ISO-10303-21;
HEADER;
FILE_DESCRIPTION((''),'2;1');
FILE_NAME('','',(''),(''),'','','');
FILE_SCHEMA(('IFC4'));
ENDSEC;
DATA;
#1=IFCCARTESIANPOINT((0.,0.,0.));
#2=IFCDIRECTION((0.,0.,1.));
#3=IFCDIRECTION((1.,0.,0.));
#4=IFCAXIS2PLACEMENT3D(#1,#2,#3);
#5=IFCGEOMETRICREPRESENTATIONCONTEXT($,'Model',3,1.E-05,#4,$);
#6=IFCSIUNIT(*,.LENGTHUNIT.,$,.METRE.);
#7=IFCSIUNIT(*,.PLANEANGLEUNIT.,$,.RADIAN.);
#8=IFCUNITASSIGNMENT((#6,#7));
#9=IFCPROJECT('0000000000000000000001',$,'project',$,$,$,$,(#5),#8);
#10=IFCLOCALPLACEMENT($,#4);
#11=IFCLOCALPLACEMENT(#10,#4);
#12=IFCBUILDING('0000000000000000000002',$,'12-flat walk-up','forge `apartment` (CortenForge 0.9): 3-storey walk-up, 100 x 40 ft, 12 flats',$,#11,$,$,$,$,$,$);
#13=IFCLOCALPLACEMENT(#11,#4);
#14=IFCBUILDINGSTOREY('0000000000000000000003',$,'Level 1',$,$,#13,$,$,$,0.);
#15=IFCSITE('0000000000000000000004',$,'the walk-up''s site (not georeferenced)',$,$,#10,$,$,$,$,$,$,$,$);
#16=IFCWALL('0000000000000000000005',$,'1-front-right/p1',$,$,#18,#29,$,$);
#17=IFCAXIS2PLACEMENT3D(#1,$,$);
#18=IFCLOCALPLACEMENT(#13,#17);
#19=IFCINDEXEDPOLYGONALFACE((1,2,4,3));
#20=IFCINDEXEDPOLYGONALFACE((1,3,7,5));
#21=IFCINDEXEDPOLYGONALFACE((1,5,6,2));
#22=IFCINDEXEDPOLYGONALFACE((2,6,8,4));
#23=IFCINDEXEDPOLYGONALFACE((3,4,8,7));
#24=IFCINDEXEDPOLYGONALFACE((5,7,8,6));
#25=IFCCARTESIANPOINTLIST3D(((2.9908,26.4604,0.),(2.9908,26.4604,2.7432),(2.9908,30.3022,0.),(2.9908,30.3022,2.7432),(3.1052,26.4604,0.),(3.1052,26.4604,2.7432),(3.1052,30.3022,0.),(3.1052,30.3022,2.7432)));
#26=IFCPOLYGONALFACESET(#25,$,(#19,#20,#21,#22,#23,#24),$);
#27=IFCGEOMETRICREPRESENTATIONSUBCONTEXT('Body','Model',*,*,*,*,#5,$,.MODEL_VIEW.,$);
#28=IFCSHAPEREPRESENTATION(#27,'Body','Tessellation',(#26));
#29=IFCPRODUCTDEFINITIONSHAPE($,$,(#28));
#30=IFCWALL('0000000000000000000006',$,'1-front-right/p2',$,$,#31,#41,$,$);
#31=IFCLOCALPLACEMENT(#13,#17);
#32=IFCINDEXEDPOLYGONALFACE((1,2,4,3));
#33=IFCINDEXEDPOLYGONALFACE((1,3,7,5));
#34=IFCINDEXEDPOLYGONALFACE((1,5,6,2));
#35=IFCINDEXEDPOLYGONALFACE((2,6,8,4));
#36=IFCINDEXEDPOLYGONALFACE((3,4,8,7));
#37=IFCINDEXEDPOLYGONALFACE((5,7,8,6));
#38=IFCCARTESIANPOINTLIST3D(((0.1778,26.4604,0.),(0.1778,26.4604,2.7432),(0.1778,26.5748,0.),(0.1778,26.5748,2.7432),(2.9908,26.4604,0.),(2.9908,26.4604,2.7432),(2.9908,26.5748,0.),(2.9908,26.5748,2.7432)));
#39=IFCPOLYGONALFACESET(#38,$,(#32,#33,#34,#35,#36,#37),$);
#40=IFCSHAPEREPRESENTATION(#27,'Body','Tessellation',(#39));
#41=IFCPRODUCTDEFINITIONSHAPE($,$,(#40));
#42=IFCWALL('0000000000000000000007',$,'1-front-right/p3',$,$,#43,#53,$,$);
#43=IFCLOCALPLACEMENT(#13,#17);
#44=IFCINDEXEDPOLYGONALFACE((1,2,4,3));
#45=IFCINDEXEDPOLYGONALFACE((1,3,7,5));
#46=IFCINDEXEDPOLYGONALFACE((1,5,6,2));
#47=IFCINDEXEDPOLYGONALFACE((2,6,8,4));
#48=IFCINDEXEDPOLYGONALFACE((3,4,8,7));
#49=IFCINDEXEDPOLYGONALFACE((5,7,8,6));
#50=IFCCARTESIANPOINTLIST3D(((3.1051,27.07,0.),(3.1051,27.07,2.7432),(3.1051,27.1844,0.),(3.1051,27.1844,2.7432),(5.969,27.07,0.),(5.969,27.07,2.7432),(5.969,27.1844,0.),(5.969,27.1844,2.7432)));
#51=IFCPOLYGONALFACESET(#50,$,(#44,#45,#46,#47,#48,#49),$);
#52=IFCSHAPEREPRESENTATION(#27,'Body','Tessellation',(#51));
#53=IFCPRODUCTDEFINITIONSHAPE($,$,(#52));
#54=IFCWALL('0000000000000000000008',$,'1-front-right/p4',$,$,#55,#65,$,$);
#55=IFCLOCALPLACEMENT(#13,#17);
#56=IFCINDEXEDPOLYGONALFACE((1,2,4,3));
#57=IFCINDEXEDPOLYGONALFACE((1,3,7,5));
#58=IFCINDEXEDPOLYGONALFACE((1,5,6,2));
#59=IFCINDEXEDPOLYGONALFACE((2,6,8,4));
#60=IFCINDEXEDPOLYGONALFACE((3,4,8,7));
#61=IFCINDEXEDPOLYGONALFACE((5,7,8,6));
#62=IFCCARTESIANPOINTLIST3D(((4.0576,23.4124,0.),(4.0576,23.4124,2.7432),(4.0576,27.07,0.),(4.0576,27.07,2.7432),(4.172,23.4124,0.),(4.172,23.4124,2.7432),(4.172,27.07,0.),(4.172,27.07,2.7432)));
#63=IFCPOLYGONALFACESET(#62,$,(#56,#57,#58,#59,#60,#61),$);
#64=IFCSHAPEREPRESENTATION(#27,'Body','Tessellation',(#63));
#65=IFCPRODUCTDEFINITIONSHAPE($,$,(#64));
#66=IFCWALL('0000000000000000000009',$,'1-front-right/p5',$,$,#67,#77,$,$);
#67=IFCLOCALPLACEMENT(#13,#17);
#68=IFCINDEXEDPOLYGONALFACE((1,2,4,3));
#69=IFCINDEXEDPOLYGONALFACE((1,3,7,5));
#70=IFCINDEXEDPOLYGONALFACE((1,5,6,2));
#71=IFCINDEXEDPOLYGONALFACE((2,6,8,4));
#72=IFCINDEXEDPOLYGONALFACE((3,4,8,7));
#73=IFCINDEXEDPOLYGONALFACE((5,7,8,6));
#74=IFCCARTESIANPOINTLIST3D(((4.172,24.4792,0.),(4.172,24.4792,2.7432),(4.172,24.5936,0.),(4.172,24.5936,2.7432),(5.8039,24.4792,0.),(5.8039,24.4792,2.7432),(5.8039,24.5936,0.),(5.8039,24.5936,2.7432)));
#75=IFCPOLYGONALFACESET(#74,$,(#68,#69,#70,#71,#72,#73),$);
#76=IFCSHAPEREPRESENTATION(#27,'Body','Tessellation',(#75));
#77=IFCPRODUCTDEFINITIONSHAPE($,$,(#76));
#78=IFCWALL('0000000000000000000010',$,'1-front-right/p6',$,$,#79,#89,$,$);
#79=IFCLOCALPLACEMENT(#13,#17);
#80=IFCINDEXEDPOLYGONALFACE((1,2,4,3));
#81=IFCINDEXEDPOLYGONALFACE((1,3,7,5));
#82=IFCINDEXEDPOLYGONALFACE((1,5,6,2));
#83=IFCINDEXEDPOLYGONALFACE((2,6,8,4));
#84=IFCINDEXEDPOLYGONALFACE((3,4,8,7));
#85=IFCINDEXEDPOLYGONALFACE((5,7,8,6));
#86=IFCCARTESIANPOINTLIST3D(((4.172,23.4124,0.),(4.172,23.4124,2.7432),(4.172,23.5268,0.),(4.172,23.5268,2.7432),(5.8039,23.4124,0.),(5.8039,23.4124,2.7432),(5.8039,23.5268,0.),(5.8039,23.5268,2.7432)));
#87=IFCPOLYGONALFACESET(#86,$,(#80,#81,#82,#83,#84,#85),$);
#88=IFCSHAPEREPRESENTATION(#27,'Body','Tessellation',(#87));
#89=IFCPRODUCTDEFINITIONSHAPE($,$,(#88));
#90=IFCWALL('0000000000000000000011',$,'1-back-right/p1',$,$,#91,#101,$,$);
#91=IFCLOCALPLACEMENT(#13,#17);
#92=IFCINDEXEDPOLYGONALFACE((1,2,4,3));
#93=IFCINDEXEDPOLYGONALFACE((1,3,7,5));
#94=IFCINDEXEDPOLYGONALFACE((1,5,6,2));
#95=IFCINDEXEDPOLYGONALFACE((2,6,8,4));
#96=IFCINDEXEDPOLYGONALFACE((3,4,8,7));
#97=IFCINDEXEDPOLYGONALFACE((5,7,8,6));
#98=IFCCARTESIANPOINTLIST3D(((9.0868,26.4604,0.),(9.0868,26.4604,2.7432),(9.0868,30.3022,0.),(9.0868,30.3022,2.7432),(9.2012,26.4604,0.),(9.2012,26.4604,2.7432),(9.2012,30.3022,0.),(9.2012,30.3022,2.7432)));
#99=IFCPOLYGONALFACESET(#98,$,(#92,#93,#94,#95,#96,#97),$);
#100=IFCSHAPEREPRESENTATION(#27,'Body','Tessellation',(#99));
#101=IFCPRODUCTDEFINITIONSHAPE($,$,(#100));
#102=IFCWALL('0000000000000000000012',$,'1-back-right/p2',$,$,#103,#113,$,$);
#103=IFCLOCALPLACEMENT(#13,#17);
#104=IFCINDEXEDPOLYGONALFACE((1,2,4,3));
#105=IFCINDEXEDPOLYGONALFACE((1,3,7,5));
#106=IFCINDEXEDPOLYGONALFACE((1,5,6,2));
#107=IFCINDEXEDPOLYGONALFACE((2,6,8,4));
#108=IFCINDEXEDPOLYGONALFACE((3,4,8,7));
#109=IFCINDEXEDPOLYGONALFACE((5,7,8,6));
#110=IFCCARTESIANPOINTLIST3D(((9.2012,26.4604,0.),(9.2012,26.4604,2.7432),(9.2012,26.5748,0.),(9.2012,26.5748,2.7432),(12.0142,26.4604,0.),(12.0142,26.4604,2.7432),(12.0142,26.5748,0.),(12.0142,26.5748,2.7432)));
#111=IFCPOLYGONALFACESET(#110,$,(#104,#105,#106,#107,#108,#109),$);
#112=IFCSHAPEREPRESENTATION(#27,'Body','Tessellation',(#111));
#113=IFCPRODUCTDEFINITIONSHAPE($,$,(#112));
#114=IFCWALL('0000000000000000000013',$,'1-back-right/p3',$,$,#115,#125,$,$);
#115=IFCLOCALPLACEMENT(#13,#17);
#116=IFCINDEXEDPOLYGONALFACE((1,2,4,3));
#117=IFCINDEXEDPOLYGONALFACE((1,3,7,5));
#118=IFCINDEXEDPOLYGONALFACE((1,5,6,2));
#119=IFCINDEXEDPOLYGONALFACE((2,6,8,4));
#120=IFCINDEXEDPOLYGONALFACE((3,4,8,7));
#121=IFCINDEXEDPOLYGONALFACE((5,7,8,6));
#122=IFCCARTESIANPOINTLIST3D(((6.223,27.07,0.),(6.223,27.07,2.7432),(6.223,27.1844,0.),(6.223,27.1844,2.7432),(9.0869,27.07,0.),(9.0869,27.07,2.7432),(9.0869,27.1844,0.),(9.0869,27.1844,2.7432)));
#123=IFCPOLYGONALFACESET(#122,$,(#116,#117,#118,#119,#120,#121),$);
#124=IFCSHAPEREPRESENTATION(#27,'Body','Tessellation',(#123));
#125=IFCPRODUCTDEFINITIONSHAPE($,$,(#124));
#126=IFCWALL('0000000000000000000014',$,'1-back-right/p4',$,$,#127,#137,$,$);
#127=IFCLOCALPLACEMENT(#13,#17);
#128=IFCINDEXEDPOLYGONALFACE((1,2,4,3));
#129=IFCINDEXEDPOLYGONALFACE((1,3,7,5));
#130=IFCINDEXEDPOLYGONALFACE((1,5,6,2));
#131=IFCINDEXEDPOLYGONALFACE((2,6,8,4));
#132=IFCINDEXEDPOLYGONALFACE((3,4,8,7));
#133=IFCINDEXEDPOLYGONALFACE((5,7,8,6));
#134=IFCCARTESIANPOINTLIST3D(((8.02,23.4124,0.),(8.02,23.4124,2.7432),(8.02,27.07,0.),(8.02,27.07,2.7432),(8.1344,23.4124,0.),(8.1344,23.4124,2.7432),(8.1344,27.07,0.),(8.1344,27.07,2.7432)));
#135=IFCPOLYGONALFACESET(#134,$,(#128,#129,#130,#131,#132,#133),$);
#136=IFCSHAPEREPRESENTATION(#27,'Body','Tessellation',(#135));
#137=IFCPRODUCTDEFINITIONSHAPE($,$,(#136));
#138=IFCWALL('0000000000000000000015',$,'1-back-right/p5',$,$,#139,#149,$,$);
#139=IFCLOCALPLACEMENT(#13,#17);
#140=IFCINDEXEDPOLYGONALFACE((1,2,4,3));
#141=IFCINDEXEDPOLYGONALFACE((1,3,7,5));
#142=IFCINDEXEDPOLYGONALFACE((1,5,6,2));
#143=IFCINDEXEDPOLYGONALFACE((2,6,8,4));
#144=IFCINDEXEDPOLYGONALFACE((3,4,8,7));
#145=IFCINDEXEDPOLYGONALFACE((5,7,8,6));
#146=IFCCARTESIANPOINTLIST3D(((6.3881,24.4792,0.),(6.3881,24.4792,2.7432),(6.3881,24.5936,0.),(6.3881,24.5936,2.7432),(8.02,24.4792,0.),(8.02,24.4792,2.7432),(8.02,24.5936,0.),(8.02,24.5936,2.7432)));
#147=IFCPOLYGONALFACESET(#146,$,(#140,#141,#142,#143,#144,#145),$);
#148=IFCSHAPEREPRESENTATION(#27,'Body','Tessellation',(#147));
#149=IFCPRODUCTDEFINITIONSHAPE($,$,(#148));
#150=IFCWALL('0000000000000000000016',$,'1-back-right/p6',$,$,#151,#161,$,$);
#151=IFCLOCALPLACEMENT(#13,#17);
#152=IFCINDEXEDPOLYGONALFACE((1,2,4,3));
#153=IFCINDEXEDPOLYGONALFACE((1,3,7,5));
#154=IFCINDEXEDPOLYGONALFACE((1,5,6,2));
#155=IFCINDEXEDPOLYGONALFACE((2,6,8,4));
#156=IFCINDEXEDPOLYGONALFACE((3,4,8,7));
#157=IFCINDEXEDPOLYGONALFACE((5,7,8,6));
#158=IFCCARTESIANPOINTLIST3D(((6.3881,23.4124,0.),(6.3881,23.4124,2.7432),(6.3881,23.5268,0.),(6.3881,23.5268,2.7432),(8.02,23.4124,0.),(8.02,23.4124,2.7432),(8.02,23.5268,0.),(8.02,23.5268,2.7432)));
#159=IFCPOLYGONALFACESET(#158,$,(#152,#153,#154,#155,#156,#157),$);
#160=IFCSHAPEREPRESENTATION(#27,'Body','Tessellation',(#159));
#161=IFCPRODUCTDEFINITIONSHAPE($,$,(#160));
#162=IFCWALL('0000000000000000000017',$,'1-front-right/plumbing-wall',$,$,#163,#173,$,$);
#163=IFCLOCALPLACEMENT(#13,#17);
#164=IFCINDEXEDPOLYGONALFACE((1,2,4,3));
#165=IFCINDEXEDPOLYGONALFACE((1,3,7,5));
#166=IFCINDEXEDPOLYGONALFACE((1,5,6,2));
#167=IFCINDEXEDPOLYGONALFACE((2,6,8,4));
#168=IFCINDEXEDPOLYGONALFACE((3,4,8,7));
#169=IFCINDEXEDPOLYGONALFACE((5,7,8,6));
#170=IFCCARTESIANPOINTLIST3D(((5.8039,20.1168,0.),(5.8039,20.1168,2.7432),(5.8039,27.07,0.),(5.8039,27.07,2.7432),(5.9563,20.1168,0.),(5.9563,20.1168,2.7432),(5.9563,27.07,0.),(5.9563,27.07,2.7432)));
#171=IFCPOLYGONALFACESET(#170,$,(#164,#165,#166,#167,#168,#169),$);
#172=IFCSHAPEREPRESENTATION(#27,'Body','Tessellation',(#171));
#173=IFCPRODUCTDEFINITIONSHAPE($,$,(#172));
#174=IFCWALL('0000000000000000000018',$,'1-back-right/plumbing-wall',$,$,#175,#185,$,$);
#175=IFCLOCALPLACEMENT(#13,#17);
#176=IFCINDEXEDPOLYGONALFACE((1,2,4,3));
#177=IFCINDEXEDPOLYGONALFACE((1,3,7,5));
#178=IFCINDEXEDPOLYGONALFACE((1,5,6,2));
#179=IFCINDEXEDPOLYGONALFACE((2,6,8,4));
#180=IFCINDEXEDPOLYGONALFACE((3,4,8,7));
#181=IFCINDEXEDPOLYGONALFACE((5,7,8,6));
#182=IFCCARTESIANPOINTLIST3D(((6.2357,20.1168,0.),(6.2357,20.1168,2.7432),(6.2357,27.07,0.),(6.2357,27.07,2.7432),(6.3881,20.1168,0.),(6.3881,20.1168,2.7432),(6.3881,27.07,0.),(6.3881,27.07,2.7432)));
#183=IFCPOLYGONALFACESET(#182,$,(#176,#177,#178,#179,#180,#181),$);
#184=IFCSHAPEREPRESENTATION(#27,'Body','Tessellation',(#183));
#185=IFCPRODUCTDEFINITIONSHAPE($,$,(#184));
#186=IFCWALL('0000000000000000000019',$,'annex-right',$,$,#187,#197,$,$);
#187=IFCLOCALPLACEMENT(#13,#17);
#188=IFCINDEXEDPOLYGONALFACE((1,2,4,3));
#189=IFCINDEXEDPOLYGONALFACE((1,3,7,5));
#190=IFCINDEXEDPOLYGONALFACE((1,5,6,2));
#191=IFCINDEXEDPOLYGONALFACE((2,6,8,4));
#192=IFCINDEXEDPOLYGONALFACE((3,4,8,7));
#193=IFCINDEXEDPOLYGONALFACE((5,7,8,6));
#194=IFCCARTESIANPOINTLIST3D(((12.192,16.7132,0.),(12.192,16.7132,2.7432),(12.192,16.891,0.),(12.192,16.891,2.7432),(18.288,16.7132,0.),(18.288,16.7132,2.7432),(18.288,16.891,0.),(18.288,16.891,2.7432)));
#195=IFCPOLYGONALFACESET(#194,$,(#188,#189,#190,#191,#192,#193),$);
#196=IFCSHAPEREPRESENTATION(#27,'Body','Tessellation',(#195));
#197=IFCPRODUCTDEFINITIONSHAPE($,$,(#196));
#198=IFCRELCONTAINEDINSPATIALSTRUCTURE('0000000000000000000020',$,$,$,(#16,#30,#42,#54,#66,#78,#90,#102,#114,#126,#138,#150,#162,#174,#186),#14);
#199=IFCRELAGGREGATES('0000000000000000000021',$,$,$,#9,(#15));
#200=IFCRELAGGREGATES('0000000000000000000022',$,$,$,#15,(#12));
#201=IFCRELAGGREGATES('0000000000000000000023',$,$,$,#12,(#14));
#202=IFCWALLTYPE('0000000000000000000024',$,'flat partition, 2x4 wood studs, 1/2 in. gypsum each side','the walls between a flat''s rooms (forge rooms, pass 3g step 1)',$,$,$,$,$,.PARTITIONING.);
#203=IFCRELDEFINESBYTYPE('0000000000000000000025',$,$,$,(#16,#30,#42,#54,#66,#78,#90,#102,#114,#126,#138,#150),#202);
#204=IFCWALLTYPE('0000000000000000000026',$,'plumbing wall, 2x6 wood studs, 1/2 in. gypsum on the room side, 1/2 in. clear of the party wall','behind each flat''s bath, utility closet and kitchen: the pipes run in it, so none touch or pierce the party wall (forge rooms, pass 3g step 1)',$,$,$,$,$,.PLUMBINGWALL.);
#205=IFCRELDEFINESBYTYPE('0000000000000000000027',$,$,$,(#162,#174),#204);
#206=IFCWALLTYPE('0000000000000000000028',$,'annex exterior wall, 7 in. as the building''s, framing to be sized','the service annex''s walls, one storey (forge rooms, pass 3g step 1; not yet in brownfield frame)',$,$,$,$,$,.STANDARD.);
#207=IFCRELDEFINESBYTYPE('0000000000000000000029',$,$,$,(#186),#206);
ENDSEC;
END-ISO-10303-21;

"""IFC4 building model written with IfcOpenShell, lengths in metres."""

from ifc_helpers import new_model, si_unit, frame, frame_2d, origin, origin_with_axes, place, context, subcontext, project, spatial, rectangle, extrude, type_object, element, save


model = new_model("IFC4")

# Units and contexts
model_context = context("Model", 3, precision=1e-05, world=origin_with_axes())
body_context = subcontext(model_context, "Body", "Model", "MODEL_VIEW")
ifc_project = project(units=[si_unit("LENGTHUNIT", "METRE"), si_unit("PLANEANGLEUNIT", "RADIAN")], contexts=[model_context])

# Site, building, storey
site_placement = place(None, origin_with_axes())
site = spatial("IfcSite", under=ifc_project, at=site_placement, Name="the walk-up's site (not georeferenced)")
building_placement = place(site_placement, origin_with_axes())
building = spatial("IfcBuilding", under=site, at=building_placement, Name="12-flat walk-up", Description="forge `apartment` (CortenForge 0.9): 3-storey walk-up, 100 x 40 ft, 12 flats")
storey_placement = place(building_placement, origin_with_axes())
storey = spatial("IfcBuildingStorey", under=building, at=storey_placement, Name="Level 1", Elevation=0.0)

# Walls
wall_type_1 = type_object("IfcWallType", Name="flat partition, 2x4 wood studs, 1/2 in. gypsum each side", Description="the walls between a flat's rooms (forge rooms, pass 3g step 1)", PredefinedType="PARTITIONING")
wall_1_placement = place(storey_placement, frame((2.9909, 26.4605, 0.0), z_axis=(0.0, 0.0, 1.0), x_axis=(1.0, 0.0, 0.0)))
element("IfcWall", 1, at=wall_1_placement, inside=storey, type_object=wall_type_1, Name="1-front-right/p1", context=body_context, shape_type="SweptSolid", body=[
    extrude(rectangle(XDim=0.1143, YDim=3.8417, at=frame_2d((0.0572, 1.9209))), origin(), (0.0, 0.0, 1.0), 2.7432),
])
wall_2_placement = place(storey_placement, frame((0.1778, 26.4605, 0.0), z_axis=(0.0, 0.0, 1.0), x_axis=(1.0, 0.0, 0.0)))
element("IfcWall", 2, at=wall_2_placement, inside=storey, type_object=wall_type_1, Name="1-front-right/p2", context=body_context, shape_type="SweptSolid", body=[
    extrude(rectangle(XDim=2.8131, YDim=0.1143, at=frame_2d((1.4065, 0.0572))), origin(), (0.0, 0.0, 1.0), 2.7432),
])
wall_3_placement = place(storey_placement, frame((3.1051, 27.07, 0.0), z_axis=(0.0, 0.0, 1.0), x_axis=(1.0, 0.0, 0.0)))
element("IfcWall", 3, at=wall_3_placement, inside=storey, type_object=wall_type_1, Name="1-front-right/p3", context=body_context, shape_type="SweptSolid", body=[
    extrude(rectangle(XDim=2.8639, YDim=0.1143, at=frame_2d((1.4319, 0.0572))), origin(), (0.0, 0.0, 1.0), 2.7432),
])
wall_4_placement = place(storey_placement, frame((4.0576, 23.4124, 0.0), z_axis=(0.0, 0.0, 1.0), x_axis=(1.0, 0.0, 0.0)))
element("IfcWall", 4, at=wall_4_placement, inside=storey, type_object=wall_type_1, Name="1-front-right/p4", context=body_context, shape_type="SweptSolid", body=[
    extrude(rectangle(XDim=0.1143, YDim=3.6576, at=frame_2d((0.0572, 1.8288))), origin(), (0.0, 0.0, 1.0), 2.7432),
])
for number, where, z_axis, x_axis, name in (
    (5, (4.1719, 24.4793, 0.0), (0.0, 0.0, 1.0), (1.0, 0.0, 0.0), "1-front-right/p5"),
    (6, (4.1719, 23.4124, 0.0), (0.0, 0.0, 1.0), (1.0, 0.0, 0.0), "1-front-right/p6"),
):
    element("IfcWall", number, at=place(storey_placement, frame(where, z_axis=z_axis, x_axis=x_axis)), inside=storey, type_object=wall_type_1, Name=name, context=body_context, shape_type="SweptSolid", body=[
        extrude(rectangle(XDim=1.6319, YDim=0.1143, at=frame_2d((0.816, 0.0572))), origin(), (0.0, 0.0, 1.0), 2.7432),
    ])
wall_5_placement = place(storey_placement, frame((9.0869, 26.4605, 0.0), z_axis=(0.0, 0.0, 1.0), x_axis=(1.0, 0.0, 0.0)))
element("IfcWall", 7, at=wall_5_placement, inside=storey, type_object=wall_type_1, Name="1-back-right/p1", context=body_context, shape_type="SweptSolid", body=[
    extrude(rectangle(XDim=0.1143, YDim=3.8417, at=frame_2d((0.0572, 1.9209))), origin(), (0.0, 0.0, 1.0), 2.7432),
])
wall_6_placement = place(storey_placement, frame((9.2012, 26.4605, 0.0), z_axis=(0.0, 0.0, 1.0), x_axis=(1.0, 0.0, 0.0)))
element("IfcWall", 8, at=wall_6_placement, inside=storey, type_object=wall_type_1, Name="1-back-right/p2", context=body_context, shape_type="SweptSolid", body=[
    extrude(rectangle(XDim=2.8131, YDim=0.1143, at=frame_2d((1.4065, 0.0572))), origin(), (0.0, 0.0, 1.0), 2.7432),
])
wall_7_placement = place(storey_placement, frame((6.223, 27.07, 0.0), z_axis=(0.0, 0.0, 1.0), x_axis=(1.0, 0.0, 0.0)))
element("IfcWall", 9, at=wall_7_placement, inside=storey, type_object=wall_type_1, Name="1-back-right/p3", context=body_context, shape_type="SweptSolid", body=[
    extrude(rectangle(XDim=2.8639, YDim=0.1143, at=frame_2d((1.4319, 0.0572))), origin(), (0.0, 0.0, 1.0), 2.7432),
])
wall_8_placement = place(storey_placement, frame((8.02, 23.4124, 0.0), z_axis=(0.0, 0.0, 1.0), x_axis=(1.0, 0.0, 0.0)))
element("IfcWall", 10, at=wall_8_placement, inside=storey, type_object=wall_type_1, Name="1-back-right/p4", context=body_context, shape_type="SweptSolid", body=[
    extrude(rectangle(XDim=0.1143, YDim=3.6576, at=frame_2d((0.0572, 1.8288))), origin(), (0.0, 0.0, 1.0), 2.7432),
])
for number, where, z_axis, x_axis, name in (
    (11, (6.3881, 24.4793, 0.0), (0.0, 0.0, 1.0), (1.0, 0.0, 0.0), "1-back-right/p5"),
    (12, (6.3881, 23.4124, 0.0), (0.0, 0.0, 1.0), (1.0, 0.0, 0.0), "1-back-right/p6"),
):
    element("IfcWall", number, at=place(storey_placement, frame(where, z_axis=z_axis, x_axis=x_axis)), inside=storey, type_object=wall_type_1, Name=name, context=body_context, shape_type="SweptSolid", body=[
        extrude(rectangle(XDim=1.6319, YDim=0.1143, at=frame_2d((0.816, 0.0572))), origin(), (0.0, 0.0, 1.0), 2.7432),
    ])
wall_type_2 = type_object("IfcWallType", Name="plumbing wall, 2x6 wood studs, 1/2 in. gypsum on the room side, 1/2 in. clear of the party wall", Description="behind each flat's bath, utility closet and kitchen: the pipes run in it, so none touch or pierce the party wall (forge rooms, pass 3g step 1)", PredefinedType="PLUMBINGWALL")
for number, where, z_axis, x_axis, name in (
    (13, (5.8039, 20.1168, 0.0), (0.0, 0.0, 1.0), (1.0, 0.0, 0.0), "1-front-right/plumbing-wall"),
    (14, (6.2357, 20.1168, 0.0), (0.0, 0.0, 1.0), (1.0, 0.0, 0.0), "1-back-right/plumbing-wall"),
):
    element("IfcWall", number, at=place(storey_placement, frame(where, z_axis=z_axis, x_axis=x_axis)), inside=storey, type_object=wall_type_2, Name=name, context=body_context, shape_type="SweptSolid", body=[
        extrude(rectangle(XDim=0.1524, YDim=6.9532, at=frame_2d((0.0762, 3.4766))), origin(), (0.0, 0.0, 1.0), 2.7432),
    ])
wall_type_3 = type_object("IfcWallType", Name="annex exterior wall, 7 in. as the building's, framing to be sized", Description="the service annex's walls, one storey (forge rooms, pass 3g step 1; not yet in brownfield frame)", PredefinedType="STANDARD")
wall_9_placement = place(storey_placement, frame((12.192, 16.7132, 0.0), z_axis=(0.0, 0.0, 1.0), x_axis=(1.0, 0.0, 0.0)))
element("IfcWall", 15, at=wall_9_placement, inside=storey, type_object=wall_type_3, Name="annex-right", context=body_context, shape_type="SweptSolid", body=[
    extrude(rectangle(XDim=6.096, YDim=0.1778, at=frame_2d((3.048, 0.0889))), origin(), (0.0, 0.0, 1.0), 2.7432),
])

save(model, "model.ifc")
